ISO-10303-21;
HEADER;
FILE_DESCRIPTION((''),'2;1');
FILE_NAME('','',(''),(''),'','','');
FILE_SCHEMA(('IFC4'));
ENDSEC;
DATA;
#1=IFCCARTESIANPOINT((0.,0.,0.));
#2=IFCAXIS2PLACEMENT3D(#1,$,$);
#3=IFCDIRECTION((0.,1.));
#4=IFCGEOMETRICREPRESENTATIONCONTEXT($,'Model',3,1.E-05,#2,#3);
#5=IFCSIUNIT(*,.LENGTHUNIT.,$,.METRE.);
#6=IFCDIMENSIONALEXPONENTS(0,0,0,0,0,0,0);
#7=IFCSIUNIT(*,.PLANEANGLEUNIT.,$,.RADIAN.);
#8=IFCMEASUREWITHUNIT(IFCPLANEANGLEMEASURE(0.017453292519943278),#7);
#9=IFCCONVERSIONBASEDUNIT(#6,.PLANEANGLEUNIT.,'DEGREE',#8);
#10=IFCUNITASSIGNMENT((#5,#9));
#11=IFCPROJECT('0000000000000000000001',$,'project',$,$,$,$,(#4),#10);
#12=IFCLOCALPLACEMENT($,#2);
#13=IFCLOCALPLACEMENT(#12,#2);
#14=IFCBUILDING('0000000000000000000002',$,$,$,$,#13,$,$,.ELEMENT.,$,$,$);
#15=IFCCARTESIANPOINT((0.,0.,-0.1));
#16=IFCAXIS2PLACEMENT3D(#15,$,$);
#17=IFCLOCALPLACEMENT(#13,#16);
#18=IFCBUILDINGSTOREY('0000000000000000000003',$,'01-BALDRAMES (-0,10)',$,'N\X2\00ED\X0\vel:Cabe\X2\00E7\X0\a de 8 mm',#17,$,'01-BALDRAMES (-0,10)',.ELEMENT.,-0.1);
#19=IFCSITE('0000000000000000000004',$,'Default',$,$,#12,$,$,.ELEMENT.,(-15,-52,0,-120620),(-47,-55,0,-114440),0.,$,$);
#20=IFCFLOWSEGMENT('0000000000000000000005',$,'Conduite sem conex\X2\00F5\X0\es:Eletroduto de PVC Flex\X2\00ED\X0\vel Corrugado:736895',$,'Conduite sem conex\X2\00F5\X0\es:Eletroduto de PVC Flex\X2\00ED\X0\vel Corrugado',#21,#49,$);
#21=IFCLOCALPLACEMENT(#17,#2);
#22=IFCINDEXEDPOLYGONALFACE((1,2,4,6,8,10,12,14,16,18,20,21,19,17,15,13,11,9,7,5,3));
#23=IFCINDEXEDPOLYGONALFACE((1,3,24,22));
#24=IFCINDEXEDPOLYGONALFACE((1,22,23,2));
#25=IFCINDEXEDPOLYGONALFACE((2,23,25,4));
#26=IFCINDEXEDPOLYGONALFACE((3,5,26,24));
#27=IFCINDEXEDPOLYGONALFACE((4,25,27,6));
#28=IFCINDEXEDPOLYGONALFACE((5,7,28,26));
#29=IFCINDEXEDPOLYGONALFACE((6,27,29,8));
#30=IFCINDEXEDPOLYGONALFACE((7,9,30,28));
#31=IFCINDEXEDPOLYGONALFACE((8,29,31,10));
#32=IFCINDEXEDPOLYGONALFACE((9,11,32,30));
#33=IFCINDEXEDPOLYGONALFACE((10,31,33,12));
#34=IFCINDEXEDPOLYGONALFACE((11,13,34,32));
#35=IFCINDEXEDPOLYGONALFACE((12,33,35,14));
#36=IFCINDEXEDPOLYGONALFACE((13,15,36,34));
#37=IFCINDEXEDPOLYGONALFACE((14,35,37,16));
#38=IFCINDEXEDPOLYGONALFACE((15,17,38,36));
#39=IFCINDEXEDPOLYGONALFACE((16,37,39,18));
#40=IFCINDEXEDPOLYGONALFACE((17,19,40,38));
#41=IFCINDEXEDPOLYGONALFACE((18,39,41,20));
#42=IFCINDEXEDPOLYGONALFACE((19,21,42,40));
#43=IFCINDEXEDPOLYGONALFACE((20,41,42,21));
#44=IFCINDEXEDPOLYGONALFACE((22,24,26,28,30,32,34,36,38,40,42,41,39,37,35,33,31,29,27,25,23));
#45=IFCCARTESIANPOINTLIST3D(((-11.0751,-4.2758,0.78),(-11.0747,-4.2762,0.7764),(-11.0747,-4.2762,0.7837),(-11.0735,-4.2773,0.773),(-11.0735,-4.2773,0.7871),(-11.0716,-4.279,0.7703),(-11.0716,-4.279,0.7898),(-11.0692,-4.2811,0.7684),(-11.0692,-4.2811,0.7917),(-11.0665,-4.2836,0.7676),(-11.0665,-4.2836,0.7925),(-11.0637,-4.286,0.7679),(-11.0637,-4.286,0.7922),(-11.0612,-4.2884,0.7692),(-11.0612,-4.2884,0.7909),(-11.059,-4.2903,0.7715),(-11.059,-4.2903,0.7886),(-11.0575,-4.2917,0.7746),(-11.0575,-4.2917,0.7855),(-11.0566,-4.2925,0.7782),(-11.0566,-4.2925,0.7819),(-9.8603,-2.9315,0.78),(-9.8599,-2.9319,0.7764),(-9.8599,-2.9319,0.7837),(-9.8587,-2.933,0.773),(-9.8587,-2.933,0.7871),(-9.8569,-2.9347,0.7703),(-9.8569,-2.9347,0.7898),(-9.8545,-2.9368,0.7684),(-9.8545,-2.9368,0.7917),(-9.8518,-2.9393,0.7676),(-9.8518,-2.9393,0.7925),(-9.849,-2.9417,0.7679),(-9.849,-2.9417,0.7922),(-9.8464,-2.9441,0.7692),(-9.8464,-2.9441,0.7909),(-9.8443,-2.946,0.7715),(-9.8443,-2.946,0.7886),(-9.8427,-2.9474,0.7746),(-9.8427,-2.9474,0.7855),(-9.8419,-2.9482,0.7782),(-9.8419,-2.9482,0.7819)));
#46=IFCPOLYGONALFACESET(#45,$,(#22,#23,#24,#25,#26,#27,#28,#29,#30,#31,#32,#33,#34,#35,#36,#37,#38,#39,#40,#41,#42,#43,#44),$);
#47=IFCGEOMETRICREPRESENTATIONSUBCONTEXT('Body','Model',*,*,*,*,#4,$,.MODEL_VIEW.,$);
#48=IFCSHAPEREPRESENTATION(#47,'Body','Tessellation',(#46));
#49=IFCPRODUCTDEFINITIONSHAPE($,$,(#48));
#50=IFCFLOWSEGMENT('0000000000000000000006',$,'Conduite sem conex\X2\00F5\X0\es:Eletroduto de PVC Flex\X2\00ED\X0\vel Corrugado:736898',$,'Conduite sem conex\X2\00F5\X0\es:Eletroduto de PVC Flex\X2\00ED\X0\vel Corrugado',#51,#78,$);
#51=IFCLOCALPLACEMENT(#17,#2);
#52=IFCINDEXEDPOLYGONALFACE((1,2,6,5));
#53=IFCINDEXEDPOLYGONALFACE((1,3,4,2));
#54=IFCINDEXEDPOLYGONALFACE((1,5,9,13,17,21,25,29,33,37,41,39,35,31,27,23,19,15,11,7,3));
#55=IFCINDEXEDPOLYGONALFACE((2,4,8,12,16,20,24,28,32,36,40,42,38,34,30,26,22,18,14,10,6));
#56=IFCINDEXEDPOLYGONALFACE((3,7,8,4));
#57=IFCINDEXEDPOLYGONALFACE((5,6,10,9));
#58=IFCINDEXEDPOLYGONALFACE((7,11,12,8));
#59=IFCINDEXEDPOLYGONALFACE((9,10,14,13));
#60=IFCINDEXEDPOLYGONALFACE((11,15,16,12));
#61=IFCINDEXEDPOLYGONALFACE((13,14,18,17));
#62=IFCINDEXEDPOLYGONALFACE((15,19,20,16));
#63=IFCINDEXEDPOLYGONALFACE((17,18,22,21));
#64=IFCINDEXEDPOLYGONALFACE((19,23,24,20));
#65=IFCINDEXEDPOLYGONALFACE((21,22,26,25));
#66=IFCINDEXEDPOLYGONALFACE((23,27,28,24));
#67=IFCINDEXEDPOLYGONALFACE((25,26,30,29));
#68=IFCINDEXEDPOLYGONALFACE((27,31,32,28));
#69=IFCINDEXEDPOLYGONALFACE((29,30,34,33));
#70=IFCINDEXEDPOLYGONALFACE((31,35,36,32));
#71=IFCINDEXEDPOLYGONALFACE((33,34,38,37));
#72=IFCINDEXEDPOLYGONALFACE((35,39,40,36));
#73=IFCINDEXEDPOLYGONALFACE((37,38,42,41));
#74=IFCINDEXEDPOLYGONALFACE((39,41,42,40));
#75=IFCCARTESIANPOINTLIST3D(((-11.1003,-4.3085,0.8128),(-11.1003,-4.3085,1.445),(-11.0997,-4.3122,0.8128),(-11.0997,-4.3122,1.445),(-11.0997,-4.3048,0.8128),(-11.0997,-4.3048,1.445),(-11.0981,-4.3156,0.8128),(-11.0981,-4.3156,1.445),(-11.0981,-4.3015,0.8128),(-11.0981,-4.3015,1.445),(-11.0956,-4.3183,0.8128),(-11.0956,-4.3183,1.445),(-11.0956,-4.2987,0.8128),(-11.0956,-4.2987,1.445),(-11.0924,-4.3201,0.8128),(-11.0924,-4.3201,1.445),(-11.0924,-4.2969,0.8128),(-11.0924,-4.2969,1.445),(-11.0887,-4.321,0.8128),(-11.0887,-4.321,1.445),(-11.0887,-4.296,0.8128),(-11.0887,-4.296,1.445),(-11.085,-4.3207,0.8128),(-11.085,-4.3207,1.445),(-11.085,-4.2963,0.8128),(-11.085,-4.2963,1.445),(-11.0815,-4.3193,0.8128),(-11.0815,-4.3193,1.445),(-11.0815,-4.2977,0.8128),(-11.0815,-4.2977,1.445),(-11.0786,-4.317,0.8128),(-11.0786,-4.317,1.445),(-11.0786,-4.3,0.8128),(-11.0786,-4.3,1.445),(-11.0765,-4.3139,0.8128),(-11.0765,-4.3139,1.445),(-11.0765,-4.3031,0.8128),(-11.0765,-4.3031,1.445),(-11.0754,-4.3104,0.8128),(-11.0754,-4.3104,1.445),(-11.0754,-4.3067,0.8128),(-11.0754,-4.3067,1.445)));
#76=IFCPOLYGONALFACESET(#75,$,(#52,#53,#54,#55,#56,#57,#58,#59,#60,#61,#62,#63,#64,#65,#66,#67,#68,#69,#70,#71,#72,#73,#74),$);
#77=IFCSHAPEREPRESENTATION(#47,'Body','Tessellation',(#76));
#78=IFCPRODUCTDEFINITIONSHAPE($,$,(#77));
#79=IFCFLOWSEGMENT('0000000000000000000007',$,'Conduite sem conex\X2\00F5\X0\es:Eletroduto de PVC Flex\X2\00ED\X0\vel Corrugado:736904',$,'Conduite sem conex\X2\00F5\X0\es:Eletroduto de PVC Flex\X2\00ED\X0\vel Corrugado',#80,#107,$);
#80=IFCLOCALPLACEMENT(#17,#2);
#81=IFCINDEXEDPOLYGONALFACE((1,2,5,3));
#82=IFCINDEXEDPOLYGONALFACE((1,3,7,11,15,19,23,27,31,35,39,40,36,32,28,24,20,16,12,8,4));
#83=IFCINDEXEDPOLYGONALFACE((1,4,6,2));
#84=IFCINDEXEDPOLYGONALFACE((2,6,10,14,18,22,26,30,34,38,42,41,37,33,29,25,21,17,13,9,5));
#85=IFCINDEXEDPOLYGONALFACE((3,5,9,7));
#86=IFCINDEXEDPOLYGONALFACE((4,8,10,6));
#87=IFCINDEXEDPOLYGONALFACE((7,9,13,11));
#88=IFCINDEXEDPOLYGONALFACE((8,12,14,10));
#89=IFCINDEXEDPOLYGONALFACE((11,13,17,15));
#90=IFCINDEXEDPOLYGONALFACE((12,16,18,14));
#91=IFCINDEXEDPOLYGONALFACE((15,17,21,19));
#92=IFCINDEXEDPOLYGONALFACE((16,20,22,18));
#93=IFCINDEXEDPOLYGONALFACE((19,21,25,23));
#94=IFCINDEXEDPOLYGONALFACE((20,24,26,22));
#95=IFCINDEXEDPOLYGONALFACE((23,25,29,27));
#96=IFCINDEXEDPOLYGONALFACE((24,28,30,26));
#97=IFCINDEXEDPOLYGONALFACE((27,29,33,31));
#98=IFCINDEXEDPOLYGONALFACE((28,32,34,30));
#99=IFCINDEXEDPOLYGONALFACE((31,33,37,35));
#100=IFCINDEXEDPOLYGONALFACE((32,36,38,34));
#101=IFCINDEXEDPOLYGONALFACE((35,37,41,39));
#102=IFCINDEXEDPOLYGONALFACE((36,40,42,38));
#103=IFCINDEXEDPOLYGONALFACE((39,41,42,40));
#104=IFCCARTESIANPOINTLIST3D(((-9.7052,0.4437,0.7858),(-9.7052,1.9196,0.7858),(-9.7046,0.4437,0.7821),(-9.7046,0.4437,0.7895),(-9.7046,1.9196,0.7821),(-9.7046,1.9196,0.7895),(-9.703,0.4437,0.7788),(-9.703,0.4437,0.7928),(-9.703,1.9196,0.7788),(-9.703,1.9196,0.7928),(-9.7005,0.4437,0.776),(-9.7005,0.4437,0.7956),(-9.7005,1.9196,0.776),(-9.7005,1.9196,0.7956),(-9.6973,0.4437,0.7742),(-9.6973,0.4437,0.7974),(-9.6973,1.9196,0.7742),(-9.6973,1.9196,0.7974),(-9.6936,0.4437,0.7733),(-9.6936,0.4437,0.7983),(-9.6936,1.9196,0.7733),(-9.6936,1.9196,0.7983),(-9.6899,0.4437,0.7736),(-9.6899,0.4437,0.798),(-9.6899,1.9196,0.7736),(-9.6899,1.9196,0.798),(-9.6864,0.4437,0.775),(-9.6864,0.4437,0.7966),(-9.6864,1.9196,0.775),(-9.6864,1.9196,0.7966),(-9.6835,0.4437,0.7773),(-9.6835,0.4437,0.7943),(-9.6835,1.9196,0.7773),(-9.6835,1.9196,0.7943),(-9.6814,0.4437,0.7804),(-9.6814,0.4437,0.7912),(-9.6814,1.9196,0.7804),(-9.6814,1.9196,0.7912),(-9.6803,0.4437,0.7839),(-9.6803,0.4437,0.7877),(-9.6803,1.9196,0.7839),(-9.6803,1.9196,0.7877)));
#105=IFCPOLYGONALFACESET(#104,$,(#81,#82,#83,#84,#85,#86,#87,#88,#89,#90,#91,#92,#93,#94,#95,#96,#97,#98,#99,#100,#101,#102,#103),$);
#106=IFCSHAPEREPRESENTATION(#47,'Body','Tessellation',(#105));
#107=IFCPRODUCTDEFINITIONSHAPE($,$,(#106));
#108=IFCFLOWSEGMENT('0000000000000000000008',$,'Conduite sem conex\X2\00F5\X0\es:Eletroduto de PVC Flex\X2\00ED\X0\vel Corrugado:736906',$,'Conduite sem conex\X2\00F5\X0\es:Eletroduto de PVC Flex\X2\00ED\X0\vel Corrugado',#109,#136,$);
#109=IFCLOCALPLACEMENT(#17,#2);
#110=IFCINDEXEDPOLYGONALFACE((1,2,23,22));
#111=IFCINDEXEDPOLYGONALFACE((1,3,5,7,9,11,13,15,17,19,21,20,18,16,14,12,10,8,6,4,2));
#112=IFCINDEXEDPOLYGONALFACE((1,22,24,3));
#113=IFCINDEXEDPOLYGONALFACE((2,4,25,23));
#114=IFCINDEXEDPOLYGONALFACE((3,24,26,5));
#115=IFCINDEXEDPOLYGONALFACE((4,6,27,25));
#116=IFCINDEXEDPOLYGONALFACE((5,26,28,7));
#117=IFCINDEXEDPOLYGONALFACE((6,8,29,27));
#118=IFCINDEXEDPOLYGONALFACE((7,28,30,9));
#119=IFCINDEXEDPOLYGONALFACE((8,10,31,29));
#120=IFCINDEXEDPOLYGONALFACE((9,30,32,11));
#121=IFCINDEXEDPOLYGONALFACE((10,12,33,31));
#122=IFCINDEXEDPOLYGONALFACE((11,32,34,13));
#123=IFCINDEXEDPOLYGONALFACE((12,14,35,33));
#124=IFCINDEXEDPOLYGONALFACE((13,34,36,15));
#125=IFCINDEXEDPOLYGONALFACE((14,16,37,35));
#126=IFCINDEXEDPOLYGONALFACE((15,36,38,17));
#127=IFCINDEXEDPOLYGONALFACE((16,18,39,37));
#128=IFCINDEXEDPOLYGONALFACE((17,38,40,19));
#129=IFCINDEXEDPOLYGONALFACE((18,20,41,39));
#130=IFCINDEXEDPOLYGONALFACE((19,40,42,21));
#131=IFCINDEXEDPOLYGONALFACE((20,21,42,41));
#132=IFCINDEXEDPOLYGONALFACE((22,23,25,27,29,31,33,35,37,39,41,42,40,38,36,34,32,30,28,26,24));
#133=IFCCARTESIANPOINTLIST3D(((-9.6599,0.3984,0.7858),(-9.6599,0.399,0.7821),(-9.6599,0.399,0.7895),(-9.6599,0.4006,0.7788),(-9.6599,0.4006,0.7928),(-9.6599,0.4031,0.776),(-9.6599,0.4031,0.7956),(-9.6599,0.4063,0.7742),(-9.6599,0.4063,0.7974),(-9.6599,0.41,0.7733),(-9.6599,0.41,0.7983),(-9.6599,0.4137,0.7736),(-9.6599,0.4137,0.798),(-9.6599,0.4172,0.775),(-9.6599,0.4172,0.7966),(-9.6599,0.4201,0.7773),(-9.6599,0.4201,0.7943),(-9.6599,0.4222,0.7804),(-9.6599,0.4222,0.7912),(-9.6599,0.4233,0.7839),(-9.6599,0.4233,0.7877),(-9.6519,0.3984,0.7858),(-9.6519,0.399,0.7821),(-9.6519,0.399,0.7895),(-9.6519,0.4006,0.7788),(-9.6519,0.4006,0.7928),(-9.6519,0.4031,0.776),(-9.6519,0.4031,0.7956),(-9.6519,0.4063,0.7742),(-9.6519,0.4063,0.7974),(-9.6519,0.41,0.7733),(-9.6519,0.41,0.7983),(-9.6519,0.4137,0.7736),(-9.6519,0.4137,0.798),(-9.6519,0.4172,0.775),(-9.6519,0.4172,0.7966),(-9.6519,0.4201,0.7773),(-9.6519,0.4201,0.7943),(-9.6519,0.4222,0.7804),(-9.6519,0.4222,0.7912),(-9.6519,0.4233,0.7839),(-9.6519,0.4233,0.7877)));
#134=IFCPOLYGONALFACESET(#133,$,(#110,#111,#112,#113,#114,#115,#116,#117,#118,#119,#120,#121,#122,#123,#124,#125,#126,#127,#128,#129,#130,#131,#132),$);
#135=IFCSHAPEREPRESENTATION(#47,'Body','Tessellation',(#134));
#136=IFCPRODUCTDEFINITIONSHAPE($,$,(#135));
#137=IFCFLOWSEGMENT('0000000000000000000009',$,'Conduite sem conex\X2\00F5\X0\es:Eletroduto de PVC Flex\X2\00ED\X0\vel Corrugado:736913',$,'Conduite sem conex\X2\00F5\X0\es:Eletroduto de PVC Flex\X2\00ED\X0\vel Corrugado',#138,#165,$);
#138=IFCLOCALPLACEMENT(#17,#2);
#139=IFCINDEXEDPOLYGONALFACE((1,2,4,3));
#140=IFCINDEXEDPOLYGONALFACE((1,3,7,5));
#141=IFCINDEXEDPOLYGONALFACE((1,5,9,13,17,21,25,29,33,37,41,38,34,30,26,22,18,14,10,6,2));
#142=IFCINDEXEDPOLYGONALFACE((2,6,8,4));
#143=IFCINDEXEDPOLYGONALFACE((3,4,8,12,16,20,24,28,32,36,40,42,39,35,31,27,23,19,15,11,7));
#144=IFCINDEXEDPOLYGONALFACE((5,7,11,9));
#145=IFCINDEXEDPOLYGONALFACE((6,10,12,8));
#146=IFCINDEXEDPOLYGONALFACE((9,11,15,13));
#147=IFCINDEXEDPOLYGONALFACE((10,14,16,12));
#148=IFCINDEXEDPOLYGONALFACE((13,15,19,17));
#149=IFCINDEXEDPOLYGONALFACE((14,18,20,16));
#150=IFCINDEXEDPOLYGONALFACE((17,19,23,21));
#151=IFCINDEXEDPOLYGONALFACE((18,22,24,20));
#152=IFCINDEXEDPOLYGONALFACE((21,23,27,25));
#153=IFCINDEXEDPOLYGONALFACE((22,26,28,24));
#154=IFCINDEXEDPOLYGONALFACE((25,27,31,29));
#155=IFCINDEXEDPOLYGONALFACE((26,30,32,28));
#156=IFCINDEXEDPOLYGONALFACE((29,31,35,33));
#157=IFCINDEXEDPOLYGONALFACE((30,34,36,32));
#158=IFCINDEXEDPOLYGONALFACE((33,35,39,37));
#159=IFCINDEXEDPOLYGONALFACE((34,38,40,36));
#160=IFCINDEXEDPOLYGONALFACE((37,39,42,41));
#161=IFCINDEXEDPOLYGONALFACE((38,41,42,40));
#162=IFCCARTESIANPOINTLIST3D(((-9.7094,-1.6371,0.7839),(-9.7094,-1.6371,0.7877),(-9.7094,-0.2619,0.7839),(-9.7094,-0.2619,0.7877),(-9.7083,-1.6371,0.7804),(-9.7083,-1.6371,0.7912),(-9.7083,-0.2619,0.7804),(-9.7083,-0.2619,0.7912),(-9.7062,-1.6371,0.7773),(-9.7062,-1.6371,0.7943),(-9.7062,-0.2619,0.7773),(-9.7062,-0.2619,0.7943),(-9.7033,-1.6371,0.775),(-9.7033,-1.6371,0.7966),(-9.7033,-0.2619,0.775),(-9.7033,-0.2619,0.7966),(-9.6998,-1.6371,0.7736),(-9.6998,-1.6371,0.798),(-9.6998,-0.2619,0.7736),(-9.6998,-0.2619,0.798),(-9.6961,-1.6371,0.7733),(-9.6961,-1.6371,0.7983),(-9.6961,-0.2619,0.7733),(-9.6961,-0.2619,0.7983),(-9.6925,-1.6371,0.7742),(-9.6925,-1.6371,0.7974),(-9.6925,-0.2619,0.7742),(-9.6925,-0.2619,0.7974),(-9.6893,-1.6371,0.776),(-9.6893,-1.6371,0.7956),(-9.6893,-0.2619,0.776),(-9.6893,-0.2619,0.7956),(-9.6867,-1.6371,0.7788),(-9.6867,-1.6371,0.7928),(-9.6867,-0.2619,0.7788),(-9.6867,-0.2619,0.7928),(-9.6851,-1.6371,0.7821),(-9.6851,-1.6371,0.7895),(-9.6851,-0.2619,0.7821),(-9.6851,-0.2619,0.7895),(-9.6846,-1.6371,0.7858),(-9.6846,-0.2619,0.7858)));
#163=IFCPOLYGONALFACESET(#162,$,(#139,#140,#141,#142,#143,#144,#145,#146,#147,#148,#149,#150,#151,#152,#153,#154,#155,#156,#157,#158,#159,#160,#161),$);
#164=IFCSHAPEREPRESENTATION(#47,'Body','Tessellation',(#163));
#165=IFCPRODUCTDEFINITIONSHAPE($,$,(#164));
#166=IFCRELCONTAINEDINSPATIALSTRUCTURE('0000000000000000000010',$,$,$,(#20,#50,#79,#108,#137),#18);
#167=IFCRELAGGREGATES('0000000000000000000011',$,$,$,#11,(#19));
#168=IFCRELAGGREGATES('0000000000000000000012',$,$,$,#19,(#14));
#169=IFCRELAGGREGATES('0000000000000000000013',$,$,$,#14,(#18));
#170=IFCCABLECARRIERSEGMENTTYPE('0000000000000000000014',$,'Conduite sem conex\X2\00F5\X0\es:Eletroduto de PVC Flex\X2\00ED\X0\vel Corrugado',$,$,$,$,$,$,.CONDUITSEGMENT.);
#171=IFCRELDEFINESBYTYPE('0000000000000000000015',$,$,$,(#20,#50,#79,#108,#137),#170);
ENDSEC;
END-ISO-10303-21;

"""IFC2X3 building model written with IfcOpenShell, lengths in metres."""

from ifc_helpers import new_model, entity, si_unit, converted_unit, direction, frame, frame_2d, origin, place, context, subcontext, project, spatial, circle, extrude, type_object, element, save


model = new_model("IFC2X3")

# Units and contexts
model_context = context("Model", 3, precision=1e-05, world=origin(), true_north=direction((0.0, 1.0)))
body_context = subcontext(model_context, "Body", "Model", "MODEL_VIEW")
ifc_project = project(units=[si_unit("LENGTHUNIT", "METRE"), converted_unit("PLANEANGLEUNIT", "DEGREE", entity("IfcPlaneAngleMeasure", 0.017453292519943278), si_unit("PLANEANGLEUNIT", "RADIAN"), dimensions=[0, 0, 0, 0, 0, 0, 0])], contexts=[model_context])

# Site, building, storey
site_placement = place(None, origin())
site = spatial("IfcSite", under=ifc_project, at=site_placement, Name="Default", CompositionType="ELEMENT", RefLatitude=(-15, -52, 0, -120620), RefLongitude=(-47, -55, 0, -114440), RefElevation=0.0)
building_placement = place(site_placement, origin())
building = spatial("IfcBuilding", under=site, at=building_placement, CompositionType="ELEMENT")
storey_placement = place(building_placement, frame((0.0, 0.0, -0.1)))
storey = spatial("IfcBuildingStorey", under=building, at=storey_placement, Name="01-BALDRAMES (-0,10)", ObjectType="Nível:Cabeça de 8 mm", LongName="01-BALDRAMES (-0,10)", CompositionType="ELEMENT", Elevation=-0.1)

# Flow segments
cable_carrier_segment_type = type_object("IfcCableCarrierSegmentType", Name="Conduite sem conexões:Eletroduto de PVC Flexível Corrugado", PredefinedType="CONDUITSEGMENT")
flow_segment_1_placement = place(storey_placement, origin())
element("IfcFlowSegment", 1, at=flow_segment_1_placement, inside=storey, type_object=cable_carrier_segment_type, Name="Conduite sem conexões:Eletroduto de PVC Flexível Corrugado:736895", ObjectType="Conduite sem conexões:Eletroduto de PVC Flexível Corrugado", context=body_context, shape_type="SweptSolid", body=[
    extrude(circle(Radius=0.0125, at=frame_2d((0.0, 0.0), x_axis=(1.0, 0.0))), frame((-11.0658, -4.2842, 0.78), z_axis=(0.670448, 0.741956, 0.0), x_axis=(-0.741956, 0.670448, 0.0)), (0.0, 0.0, 1.0), 1.8118),
])
flow_segment_2_placement = place(storey_placement, origin())
element("IfcFlowSegment", 2, at=flow_segment_2_placement, inside=storey, type_object=cable_carrier_segment_type, Name="Conduite sem conexões:Eletroduto de PVC Flexível Corrugado:736898", ObjectType="Conduite sem conexões:Eletroduto de PVC Flexível Corrugado", context=body_context, shape_type="SweptSolid", body=[
    extrude(circle(Radius=0.0125, at=frame_2d((0.0, 0.0), x_axis=(1.0, 0.0))), frame((-11.0878, -4.3085, 0.8128), z_axis=(0.0, 0.0, 1.0), x_axis=(-1.0, 0.0, 0.0)), (0.0, 0.0, 1.0), 0.6322),
])
flow_segment_3_placement = place(storey_placement, origin())
element("IfcFlowSegment", 3, at=flow_segment_3_placement, inside=storey, type_object=cable_carrier_segment_type, Name="Conduite sem conexões:Eletroduto de PVC Flexível Corrugado:736904", ObjectType="Conduite sem conexões:Eletroduto de PVC Flexível Corrugado", context=body_context, shape_type="SweptSolid", body=[
    extrude(circle(Radius=0.0125, at=frame_2d((0.0, 0.0), x_axis=(1.0, 0.0))), frame((-9.6927, 0.4437, 0.7858), z_axis=(0.0, 1.0, 0.0), x_axis=(-1.0, 0.0, 0.0)), (0.0, 0.0, 1.0), 1.4758),
])
flow_segment_4_placement = place(storey_placement, origin())
element("IfcFlowSegment", 4, at=flow_segment_4_placement, inside=storey, type_object=cable_carrier_segment_type, Name="Conduite sem conexões:Eletroduto de PVC Flexível Corrugado:736906", ObjectType="Conduite sem conexões:Eletroduto de PVC Flexível Corrugado", context=body_context, shape_type="SweptSolid", body=[
    extrude(circle(Radius=0.0125, at=frame_2d((0.0, 0.0), x_axis=(1.0, 0.0))), frame((-9.6599, 0.4109, 0.7858), z_axis=(1.0, 0.0, 0.0), x_axis=(0.0, -1.0, 0.0)), (0.0, 0.0, 1.0), 0.008),
])
flow_segment_5_placement = place(storey_placement, origin())
element("IfcFlowSegment", 5, at=flow_segment_5_placement, inside=storey, type_object=cable_carrier_segment_type, Name="Conduite sem conexões:Eletroduto de PVC Flexível Corrugado:736913", ObjectType="Conduite sem conexões:Eletroduto de PVC Flexível Corrugado", context=body_context, shape_type="SweptSolid", body=[
    extrude(circle(Radius=0.0125, at=frame_2d((0.0, 0.0), x_axis=(1.0, 0.0))), frame((-9.6971, -1.6371, 0.7858), z_axis=(0.0, 1.0, 0.0), x_axis=(1.0, 0.0, 0.0)), (0.0, 0.0, 1.0), 1.3752),
])

save(model, "model.ifc")
